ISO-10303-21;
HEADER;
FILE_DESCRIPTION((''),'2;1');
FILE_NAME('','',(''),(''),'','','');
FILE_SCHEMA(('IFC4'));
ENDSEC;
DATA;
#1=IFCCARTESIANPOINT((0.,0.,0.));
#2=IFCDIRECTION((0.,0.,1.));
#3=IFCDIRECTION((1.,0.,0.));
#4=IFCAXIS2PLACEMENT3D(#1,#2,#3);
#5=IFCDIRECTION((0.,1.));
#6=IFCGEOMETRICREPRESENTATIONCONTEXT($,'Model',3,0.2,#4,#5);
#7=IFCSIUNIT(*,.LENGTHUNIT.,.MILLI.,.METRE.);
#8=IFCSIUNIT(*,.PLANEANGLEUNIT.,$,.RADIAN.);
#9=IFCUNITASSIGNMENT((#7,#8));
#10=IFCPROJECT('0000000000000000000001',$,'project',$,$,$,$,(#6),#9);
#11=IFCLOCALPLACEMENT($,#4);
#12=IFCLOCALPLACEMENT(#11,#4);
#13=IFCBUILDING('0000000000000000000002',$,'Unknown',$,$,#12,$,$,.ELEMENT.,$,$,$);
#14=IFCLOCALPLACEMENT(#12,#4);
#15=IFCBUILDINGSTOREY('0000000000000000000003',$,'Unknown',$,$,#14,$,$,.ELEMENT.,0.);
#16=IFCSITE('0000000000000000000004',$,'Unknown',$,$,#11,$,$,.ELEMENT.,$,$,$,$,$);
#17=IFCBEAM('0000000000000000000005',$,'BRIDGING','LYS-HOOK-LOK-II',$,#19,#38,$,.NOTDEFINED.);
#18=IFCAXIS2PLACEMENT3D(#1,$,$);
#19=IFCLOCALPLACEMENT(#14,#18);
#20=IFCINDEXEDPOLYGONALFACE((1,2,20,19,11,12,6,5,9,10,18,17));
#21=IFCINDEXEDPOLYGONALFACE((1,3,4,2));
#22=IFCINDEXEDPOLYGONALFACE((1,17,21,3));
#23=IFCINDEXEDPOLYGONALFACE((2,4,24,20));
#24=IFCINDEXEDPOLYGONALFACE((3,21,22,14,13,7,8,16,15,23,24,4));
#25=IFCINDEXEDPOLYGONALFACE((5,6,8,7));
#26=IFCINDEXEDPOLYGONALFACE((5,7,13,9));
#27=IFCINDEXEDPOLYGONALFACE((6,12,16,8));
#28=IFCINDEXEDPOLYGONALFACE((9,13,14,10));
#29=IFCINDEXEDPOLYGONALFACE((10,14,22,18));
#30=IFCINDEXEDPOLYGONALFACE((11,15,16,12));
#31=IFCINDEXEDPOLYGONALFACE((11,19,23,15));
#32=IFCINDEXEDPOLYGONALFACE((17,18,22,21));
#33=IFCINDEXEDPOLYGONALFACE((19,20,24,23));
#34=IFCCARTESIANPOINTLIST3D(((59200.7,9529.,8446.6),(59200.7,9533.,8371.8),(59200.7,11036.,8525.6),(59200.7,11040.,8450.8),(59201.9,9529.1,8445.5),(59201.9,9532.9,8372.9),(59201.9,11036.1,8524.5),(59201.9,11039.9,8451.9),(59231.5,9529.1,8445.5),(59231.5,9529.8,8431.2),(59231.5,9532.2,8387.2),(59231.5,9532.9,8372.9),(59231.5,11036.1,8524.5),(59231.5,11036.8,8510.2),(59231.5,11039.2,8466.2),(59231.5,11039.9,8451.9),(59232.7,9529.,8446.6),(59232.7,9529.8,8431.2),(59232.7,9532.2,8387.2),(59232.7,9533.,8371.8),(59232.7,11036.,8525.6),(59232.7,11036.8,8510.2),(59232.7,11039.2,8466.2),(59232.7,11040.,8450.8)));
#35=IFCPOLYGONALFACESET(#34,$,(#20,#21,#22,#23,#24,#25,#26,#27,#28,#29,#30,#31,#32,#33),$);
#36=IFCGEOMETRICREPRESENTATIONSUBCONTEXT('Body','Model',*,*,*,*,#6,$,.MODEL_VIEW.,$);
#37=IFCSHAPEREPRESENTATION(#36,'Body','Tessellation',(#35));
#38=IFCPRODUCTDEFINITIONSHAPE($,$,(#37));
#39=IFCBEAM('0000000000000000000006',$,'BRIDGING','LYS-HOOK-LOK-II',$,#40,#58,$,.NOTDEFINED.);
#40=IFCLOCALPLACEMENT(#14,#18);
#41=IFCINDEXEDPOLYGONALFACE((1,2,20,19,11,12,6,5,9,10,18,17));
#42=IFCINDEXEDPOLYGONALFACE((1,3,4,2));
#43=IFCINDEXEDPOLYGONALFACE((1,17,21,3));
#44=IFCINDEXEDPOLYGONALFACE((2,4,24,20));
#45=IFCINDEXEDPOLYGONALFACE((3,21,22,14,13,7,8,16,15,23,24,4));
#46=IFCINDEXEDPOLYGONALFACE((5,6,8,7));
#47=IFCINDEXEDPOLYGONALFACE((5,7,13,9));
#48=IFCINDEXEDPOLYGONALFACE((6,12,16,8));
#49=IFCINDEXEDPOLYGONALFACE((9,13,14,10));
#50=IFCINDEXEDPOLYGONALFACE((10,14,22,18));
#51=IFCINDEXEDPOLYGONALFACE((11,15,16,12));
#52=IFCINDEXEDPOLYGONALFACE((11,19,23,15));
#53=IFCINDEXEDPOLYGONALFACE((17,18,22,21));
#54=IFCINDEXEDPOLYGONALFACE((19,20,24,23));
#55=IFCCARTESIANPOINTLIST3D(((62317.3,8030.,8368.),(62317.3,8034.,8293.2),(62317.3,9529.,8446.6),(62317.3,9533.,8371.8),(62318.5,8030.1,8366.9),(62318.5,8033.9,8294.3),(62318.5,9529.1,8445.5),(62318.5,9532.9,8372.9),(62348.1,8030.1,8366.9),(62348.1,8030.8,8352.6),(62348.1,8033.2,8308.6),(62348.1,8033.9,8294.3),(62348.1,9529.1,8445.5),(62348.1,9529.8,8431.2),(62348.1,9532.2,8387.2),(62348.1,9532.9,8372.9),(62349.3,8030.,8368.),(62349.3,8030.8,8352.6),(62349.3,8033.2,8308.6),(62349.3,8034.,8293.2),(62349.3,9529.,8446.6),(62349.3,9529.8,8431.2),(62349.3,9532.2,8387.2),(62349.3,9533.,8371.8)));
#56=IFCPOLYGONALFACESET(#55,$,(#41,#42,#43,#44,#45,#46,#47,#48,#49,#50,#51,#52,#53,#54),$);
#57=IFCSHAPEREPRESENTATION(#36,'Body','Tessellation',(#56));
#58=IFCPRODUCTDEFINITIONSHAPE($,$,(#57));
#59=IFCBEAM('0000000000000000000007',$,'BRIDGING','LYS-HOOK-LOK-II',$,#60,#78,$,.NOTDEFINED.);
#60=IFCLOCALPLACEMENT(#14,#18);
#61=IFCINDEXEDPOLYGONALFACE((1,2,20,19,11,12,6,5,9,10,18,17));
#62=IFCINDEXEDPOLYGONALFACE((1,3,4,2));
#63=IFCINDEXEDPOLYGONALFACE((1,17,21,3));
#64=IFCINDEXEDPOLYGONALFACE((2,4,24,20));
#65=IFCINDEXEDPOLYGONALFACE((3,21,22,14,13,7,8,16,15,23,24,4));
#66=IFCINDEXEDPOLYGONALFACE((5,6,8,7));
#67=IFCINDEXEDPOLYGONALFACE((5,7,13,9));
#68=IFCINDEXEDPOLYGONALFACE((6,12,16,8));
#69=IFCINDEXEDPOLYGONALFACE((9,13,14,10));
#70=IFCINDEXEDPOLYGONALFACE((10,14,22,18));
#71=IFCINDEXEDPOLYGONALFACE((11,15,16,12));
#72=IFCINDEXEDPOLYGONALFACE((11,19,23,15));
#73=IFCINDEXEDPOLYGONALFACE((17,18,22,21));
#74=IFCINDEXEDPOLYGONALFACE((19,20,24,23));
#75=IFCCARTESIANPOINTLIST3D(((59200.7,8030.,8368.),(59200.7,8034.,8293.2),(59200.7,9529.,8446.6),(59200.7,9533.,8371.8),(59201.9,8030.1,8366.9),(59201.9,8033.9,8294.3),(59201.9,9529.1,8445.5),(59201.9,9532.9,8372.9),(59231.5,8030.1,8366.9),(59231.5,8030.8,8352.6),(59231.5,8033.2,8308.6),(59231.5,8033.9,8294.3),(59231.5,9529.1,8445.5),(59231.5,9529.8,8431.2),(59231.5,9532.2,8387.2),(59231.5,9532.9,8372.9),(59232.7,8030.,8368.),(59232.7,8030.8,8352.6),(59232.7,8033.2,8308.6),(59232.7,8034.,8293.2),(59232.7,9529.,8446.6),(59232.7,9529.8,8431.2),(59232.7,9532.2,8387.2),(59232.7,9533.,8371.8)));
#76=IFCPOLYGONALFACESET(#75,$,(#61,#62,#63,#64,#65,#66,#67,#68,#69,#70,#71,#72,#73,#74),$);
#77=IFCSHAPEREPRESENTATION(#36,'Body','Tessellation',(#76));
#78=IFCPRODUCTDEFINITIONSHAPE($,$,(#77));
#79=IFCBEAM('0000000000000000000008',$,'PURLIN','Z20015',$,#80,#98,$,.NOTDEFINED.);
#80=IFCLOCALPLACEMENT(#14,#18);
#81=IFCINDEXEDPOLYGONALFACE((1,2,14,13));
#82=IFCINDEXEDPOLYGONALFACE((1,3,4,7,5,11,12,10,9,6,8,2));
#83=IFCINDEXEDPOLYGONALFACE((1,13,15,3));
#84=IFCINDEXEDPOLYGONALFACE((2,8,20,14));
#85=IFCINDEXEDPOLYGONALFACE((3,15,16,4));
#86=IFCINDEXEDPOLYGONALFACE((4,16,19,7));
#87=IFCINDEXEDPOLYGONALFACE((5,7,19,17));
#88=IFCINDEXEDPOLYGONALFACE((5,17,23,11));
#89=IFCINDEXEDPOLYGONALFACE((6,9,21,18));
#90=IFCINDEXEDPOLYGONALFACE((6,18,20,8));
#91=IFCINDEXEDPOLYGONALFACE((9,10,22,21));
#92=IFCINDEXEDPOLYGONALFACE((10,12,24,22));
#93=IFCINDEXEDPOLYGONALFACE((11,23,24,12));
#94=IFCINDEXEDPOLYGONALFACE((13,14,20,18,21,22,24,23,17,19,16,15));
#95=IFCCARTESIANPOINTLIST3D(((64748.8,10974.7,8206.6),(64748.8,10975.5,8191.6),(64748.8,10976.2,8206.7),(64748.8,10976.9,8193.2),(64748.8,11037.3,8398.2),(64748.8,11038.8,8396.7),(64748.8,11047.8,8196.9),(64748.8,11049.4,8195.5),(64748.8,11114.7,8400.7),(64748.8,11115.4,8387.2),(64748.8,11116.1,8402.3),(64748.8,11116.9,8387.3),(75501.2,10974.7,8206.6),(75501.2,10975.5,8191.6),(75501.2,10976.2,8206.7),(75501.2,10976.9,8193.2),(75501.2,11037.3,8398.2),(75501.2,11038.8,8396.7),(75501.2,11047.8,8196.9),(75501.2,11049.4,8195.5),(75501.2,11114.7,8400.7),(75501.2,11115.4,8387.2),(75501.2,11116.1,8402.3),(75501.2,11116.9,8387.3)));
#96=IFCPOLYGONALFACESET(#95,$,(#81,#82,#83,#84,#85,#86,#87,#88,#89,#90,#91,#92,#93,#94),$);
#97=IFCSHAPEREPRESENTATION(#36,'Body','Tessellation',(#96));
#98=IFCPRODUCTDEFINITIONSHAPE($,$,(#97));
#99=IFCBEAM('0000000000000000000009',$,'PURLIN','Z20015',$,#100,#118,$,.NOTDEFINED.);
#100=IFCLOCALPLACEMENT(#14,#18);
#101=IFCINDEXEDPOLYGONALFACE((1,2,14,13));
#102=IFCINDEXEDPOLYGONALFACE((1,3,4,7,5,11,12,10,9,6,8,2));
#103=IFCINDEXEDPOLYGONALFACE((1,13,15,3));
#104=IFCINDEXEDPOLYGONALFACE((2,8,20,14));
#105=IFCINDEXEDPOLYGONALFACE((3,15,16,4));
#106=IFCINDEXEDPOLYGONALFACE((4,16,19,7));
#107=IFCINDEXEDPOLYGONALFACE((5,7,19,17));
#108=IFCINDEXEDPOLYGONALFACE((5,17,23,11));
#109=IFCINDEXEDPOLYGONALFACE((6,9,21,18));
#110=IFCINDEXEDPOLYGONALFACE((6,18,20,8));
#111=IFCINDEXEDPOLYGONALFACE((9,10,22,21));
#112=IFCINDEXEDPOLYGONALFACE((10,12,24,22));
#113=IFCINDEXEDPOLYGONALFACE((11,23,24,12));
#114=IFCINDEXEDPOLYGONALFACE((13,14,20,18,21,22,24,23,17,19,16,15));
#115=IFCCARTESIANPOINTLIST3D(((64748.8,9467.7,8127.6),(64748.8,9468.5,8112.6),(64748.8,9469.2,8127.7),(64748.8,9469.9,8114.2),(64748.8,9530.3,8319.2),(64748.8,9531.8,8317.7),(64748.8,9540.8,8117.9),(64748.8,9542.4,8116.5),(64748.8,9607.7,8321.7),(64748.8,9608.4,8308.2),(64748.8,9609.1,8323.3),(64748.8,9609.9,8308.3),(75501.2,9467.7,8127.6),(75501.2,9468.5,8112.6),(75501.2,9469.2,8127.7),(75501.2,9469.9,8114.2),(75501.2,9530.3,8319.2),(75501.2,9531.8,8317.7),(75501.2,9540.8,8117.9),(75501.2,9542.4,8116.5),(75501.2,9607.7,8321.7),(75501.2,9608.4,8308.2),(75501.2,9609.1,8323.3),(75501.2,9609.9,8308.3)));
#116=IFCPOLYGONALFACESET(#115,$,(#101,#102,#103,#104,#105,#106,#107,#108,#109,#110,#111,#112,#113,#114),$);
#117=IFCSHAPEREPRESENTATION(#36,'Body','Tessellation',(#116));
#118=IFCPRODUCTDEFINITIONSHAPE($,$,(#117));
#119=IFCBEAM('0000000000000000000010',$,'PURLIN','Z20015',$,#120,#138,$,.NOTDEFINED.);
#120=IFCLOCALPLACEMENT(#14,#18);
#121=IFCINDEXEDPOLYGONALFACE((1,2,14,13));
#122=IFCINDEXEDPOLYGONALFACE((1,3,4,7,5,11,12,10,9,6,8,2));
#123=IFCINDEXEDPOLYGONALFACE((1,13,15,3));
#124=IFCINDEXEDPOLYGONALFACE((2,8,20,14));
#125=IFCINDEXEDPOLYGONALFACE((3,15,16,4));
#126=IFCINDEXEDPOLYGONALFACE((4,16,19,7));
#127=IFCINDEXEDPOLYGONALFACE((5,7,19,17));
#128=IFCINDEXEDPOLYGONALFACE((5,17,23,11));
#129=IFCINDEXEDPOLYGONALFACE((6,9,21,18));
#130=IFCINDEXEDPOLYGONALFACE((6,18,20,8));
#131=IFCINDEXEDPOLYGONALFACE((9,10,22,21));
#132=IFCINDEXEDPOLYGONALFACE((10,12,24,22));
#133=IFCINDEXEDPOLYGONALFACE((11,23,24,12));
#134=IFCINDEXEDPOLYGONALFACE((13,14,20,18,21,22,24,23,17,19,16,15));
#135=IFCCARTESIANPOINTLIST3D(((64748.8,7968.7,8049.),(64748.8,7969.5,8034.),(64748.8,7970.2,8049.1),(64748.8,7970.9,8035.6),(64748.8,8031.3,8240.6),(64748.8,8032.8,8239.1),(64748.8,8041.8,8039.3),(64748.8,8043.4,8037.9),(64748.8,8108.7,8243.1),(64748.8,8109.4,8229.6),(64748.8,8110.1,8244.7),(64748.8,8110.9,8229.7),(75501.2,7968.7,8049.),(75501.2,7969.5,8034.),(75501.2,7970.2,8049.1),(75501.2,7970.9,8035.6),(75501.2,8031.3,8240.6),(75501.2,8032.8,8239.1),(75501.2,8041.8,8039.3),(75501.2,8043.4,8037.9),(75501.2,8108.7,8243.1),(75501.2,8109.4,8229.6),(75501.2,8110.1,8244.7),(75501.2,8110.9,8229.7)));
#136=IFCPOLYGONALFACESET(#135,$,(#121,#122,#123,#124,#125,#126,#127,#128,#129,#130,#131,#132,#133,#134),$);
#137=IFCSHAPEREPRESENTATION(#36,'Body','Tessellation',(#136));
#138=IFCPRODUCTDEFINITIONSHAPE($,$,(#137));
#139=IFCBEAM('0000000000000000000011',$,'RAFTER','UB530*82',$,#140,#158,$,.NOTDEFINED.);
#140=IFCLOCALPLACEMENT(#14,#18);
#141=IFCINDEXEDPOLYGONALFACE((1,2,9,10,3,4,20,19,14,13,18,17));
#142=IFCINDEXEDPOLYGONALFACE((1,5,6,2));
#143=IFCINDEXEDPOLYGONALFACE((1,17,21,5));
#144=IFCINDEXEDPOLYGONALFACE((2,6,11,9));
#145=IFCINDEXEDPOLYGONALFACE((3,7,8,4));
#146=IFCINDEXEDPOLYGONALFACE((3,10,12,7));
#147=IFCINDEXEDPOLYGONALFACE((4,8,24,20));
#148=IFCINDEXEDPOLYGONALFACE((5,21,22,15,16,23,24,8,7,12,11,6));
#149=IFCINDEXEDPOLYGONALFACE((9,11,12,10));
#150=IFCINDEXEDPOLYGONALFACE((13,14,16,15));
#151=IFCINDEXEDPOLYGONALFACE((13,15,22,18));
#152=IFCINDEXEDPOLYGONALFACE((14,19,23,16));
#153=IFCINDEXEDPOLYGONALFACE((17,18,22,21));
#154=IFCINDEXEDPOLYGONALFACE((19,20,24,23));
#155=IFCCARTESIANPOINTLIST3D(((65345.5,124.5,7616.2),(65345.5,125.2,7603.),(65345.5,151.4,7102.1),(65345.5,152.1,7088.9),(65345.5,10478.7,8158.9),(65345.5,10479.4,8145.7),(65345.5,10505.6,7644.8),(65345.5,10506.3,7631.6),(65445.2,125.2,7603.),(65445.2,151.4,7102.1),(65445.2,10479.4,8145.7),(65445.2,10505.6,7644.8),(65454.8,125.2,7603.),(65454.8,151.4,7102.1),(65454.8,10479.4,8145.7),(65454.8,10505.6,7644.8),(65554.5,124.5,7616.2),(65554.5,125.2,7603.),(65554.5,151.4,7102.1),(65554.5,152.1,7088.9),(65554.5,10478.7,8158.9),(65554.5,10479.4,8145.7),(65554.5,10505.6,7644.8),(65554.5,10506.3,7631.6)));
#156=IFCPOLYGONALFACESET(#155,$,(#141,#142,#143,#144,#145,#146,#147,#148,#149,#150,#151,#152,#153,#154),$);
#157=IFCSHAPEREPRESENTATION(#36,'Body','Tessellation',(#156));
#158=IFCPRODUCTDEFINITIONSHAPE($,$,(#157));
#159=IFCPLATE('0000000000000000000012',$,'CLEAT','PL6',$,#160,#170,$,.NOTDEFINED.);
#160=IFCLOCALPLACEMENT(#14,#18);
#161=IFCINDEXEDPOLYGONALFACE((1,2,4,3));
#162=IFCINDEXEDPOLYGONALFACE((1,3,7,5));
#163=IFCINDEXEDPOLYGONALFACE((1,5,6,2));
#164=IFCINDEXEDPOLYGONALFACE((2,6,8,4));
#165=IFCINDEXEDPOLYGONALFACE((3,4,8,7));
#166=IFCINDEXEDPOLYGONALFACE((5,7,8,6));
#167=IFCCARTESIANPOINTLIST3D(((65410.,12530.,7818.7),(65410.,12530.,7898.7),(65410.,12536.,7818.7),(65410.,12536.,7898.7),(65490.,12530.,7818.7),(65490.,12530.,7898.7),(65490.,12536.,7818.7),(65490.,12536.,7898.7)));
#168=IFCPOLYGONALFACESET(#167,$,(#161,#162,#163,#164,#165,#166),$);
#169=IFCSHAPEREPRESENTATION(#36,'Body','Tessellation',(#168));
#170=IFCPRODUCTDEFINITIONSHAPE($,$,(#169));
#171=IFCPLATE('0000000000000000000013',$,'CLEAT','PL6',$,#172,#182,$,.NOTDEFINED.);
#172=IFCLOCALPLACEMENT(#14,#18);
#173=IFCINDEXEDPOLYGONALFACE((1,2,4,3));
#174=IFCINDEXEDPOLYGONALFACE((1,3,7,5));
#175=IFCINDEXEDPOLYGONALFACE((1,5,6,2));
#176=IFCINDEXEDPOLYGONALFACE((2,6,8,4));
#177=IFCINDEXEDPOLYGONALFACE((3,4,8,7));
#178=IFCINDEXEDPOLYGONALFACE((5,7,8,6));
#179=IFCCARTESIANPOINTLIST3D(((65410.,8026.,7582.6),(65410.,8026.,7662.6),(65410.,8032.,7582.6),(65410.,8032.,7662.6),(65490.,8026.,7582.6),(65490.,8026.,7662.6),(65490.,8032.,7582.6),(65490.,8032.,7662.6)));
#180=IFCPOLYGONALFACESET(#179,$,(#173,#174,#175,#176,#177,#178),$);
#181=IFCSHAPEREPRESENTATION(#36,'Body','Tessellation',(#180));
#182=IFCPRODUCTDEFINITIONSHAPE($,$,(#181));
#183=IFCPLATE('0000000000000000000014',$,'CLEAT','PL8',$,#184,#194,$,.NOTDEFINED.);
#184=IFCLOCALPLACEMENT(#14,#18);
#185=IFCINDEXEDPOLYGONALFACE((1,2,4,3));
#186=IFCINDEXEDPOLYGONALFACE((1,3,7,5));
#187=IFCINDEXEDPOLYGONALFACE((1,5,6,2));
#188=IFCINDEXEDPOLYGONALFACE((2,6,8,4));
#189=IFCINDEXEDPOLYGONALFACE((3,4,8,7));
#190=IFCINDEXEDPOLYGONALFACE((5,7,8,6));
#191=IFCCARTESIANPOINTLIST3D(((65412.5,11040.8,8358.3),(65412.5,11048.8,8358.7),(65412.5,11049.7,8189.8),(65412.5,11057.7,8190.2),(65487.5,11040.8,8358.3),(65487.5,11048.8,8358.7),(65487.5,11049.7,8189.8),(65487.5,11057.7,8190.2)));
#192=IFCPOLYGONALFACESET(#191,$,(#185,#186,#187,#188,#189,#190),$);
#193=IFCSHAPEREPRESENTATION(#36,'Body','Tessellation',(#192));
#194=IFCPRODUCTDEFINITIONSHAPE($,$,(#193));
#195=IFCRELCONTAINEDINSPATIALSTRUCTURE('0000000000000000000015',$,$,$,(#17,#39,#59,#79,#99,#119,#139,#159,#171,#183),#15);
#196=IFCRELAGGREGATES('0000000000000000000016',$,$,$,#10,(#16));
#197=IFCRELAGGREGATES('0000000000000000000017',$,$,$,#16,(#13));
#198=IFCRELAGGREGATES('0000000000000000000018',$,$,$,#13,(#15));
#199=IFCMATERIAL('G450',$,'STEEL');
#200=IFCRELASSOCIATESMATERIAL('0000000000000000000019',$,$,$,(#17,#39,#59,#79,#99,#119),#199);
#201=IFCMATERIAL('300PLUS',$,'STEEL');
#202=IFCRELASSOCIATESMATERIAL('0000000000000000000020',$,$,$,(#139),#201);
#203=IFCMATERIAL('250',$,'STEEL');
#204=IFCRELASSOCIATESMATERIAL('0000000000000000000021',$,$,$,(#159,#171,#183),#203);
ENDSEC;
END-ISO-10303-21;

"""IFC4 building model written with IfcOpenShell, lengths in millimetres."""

from ifc_helpers import new_model, si_unit, direction, frame, origin_with_axes, place, context, subcontext, project, spatial, line, indexed_curve, outline, extrude, material, element, save


model = new_model("IFC4")

# Units and contexts
model_context = context("Model", 3, precision=0.2, world=origin_with_axes(), true_north=direction((0.0, 1.0)))
body_context = subcontext(model_context, "Body", "Model", "MODEL_VIEW")
ifc_project = project(units=[si_unit("LENGTHUNIT", "METRE", prefix="MILLI"), si_unit("PLANEANGLEUNIT", "RADIAN")], contexts=[model_context])

# Site, building, storey
site_placement = place(None, origin_with_axes())
site = spatial("IfcSite", under=ifc_project, at=site_placement, Name="Unknown", CompositionType="ELEMENT")
building_placement = place(site_placement, origin_with_axes())
building = spatial("IfcBuilding", under=site, at=building_placement, Name="Unknown", CompositionType="ELEMENT")
storey_placement = place(building_placement, origin_with_axes())
storey = spatial("IfcBuildingStorey", under=building, at=storey_placement, Name="Unknown", CompositionType="ELEMENT", Elevation=0.0)

# Shared definitions
ifc_material_1 = material(Name="300PLUS", Category="STEEL")

# Beams
ifc_material_2 = material(Name="G450", Category="STEEL")
for number, where, z_axis, x_axis, name in (
    (1, (59216.7, 9531.0, 8409.2), (1.0, 0.0, 0.0), (0.0, 0.998629, 0.05235), "BRIDGING"),
):
    element("IfcBeam", number, at=place(storey_placement, frame(where, z_axis=z_axis, x_axis=x_axis)), inside=storey, material=ifc_material_2, Name=name, Description="LYS-HOOK-LOK-II", PredefinedType="NOTDEFINED", context=body_context, shape_type="SolidModel", body=[
        extrude(outline(indexed_curve([(16.0, -37.5), (16.0, -22.0), (14.8, -22.0), (14.8, -36.3), (-14.8, -36.3), (-14.8, 36.3), (14.8, 36.3), (14.8, 22.0), (16.0, 22.0), (16.0, 37.5), (-16.0, 37.5), (-16.0, -37.5)], segments=[line(1, 2, 3, 4, 5, 6, 7, 8, 9, 10, 11, 12, 1)])), frame((0.0, 0.0, 0.0), z_axis=(-1.0, 0.0, 0.0), x_axis=(0.0, 0.0, 1.0)), (0.0, 0.0, -1.0), 1509.1),
    ])
for number, where, z_axis, x_axis, name in (
    (2, (62333.3, 8032.0, 8330.6), (1.0, 0.0, 0.0), (0.0, 0.998628, 0.052363), "BRIDGING"),
    (3, (59216.7, 8032.0, 8330.6), (1.0, 0.0, 0.0), (0.0, 0.998628, 0.052363), "BRIDGING"),
):
    element("IfcBeam", number, at=place(storey_placement, frame(where, z_axis=z_axis, x_axis=x_axis)), inside=storey, material=ifc_material_2, Name=name, Description="LYS-HOOK-LOK-II", PredefinedType="NOTDEFINED", context=body_context, shape_type="SolidModel", body=[
        extrude(outline(indexed_curve([(16.0, -37.5), (16.0, -22.0), (14.8, -22.0), (14.8, -36.3), (-14.8, -36.3), (-14.8, 36.3), (14.8, 36.3), (14.8, 22.0), (16.0, 22.0), (16.0, 37.5), (-16.0, 37.5), (-16.0, -37.5)], segments=[line(1, 2, 3, 4, 5, 6, 7, 8, 9, 10, 11, 12, 1)])), frame((0.0, 0.0, 0.0), z_axis=(-1.0, 0.0, 0.0), x_axis=(0.0, 0.0, 1.0)), (0.0, 0.0, -1.0), 1501.1),
    ])
for number, where, z_axis, x_axis, name in (
    (4, (64748.8, 11043.3, 8296.8), (0.0, -0.99863, -0.052336), (1.0, 0.0, 0.0), "PURLIN"),
    (5, (64748.8, 9536.3, 8217.8), (0.0, -0.99863, -0.052336), (1.0, 0.0, 0.0), "PURLIN"),
    (6, (64748.8, 8037.3, 8139.2), (0.0, -0.99863, -0.052336), (1.0, 0.0, 0.0), "PURLIN"),
):
    element("IfcBeam", number, at=place(storey_placement, frame(where, z_axis=z_axis, x_axis=x_axis)), inside=storey, material=ifc_material_2, Name=name, Description="Z20015", PredefinedType="NOTDEFINED", context=body_context, shape_type="SolidModel", body=[
        extrude(outline(indexed_curve([(73.2, -101.5), (73.2, -86.5), (71.8, -86.5), (71.8, -100.0), (0.8, -100.0), (0.8, 101.5), (-78.2, 101.5), (-78.2, 86.5), (-76.8, 86.5), (-76.8, 100.0), (-0.8, 100.0), (-0.8, -101.5)], segments=[line(1, 2, 3, 4, 5, 6, 7, 8, 9, 10, 11, 12, 1)])), frame((0.0, 0.0, 0.0), z_axis=(-1.0, 0.0, 0.0), x_axis=(0.0, 0.0, 1.0)), (0.0, 0.0, -1.0), 10752.4),
    ])
beam_placement = place(storey_placement, frame((65450.0, 10492.5, 7895.3), z_axis=(-1.0, 0.0, 0.0), x_axis=(0.0, -0.998629, -0.052342)))
element("IfcBeam", 7, at=beam_placement, inside=storey, material=ifc_material_1, Name="RAFTER", Description="UB530*82", PredefinedType="NOTDEFINED", context=body_context, shape_type="SolidModel", body=[
    extrude(outline(indexed_curve([(-104.5, -264.0), (104.5, -264.0), (104.5, -250.8), (4.8, -250.8), (4.8, 250.8), (104.5, 250.8), (104.5, 264.0), (-104.5, 264.0), (-104.5, 250.8), (-4.8, 250.8), (-4.8, -250.8), (-104.5, -250.8)], segments=[line(1, 2, 3, 4, 5, 6, 7, 8, 9, 10, 11, 12, 1)])), frame((0.0, 0.0, 0.0), z_axis=(-1.0, 0.0, 0.0), x_axis=(0.0, 0.0, 1.0)), (0.0, 0.0, -1.0), 10368.4),
])

# Plates
ifc_material_3 = material(Name="250", Category="STEEL")
for number, where, z_axis, x_axis, name in (
    (8, (65410.0, 12533.0, 7818.7), (0.0, -1.0, 0.0), (1.0, 0.0, 0.0), "CLEAT"),
    (9, (65410.0, 8029.0, 7582.6), (0.0, -1.0, 0.0), (1.0, 0.0, 0.0), "CLEAT"),
):
    element("IfcPlate", number, at=place(storey_placement, frame(where, z_axis=z_axis, x_axis=x_axis)), inside=storey, material=ifc_material_3, Name=name, Description="PL6", PredefinedType="NOTDEFINED", context=body_context, shape_type="SolidModel", body=[
        extrude(outline(indexed_curve([(0.0, 0.0), (80.0, 0.0), (80.0, 80.0), (0.0, 80.0)], segments=[line(1, 2, 3, 4, 1)])), frame((0.0, 0.0, 3.0), z_axis=(0.0, 0.0, 1.0), x_axis=(1.0, 0.0, 0.0)), (0.0, 0.0, -1.0), 6.0),
    ])
plate_1_placement = place(storey_placement, frame((65412.5, 11044.8, 8358.5), z_axis=(0.0, 0.998608, 0.052745), x_axis=(1.0, 0.0, 0.0)))
element("IfcPlate", 10, at=plate_1_placement, inside=storey, material=ifc_material_3, Name="CLEAT", Description="PL8", PredefinedType="NOTDEFINED", context=body_context, shape_type="SolidModel", body=[
    extrude(outline(indexed_curve([(0.0, 0.0), (75.0, 0.0), (75.0, 168.7), (0.0, 168.7)], segments=[line(1, 2, 3, 4, 1)])), frame((0.0, 0.0, 4.0), z_axis=(0.0, 0.0, 1.0), x_axis=(1.0, 0.0, 0.0)), (0.0, 0.0, -1.0), 8.0),
])

save(model, "model.ifc")
